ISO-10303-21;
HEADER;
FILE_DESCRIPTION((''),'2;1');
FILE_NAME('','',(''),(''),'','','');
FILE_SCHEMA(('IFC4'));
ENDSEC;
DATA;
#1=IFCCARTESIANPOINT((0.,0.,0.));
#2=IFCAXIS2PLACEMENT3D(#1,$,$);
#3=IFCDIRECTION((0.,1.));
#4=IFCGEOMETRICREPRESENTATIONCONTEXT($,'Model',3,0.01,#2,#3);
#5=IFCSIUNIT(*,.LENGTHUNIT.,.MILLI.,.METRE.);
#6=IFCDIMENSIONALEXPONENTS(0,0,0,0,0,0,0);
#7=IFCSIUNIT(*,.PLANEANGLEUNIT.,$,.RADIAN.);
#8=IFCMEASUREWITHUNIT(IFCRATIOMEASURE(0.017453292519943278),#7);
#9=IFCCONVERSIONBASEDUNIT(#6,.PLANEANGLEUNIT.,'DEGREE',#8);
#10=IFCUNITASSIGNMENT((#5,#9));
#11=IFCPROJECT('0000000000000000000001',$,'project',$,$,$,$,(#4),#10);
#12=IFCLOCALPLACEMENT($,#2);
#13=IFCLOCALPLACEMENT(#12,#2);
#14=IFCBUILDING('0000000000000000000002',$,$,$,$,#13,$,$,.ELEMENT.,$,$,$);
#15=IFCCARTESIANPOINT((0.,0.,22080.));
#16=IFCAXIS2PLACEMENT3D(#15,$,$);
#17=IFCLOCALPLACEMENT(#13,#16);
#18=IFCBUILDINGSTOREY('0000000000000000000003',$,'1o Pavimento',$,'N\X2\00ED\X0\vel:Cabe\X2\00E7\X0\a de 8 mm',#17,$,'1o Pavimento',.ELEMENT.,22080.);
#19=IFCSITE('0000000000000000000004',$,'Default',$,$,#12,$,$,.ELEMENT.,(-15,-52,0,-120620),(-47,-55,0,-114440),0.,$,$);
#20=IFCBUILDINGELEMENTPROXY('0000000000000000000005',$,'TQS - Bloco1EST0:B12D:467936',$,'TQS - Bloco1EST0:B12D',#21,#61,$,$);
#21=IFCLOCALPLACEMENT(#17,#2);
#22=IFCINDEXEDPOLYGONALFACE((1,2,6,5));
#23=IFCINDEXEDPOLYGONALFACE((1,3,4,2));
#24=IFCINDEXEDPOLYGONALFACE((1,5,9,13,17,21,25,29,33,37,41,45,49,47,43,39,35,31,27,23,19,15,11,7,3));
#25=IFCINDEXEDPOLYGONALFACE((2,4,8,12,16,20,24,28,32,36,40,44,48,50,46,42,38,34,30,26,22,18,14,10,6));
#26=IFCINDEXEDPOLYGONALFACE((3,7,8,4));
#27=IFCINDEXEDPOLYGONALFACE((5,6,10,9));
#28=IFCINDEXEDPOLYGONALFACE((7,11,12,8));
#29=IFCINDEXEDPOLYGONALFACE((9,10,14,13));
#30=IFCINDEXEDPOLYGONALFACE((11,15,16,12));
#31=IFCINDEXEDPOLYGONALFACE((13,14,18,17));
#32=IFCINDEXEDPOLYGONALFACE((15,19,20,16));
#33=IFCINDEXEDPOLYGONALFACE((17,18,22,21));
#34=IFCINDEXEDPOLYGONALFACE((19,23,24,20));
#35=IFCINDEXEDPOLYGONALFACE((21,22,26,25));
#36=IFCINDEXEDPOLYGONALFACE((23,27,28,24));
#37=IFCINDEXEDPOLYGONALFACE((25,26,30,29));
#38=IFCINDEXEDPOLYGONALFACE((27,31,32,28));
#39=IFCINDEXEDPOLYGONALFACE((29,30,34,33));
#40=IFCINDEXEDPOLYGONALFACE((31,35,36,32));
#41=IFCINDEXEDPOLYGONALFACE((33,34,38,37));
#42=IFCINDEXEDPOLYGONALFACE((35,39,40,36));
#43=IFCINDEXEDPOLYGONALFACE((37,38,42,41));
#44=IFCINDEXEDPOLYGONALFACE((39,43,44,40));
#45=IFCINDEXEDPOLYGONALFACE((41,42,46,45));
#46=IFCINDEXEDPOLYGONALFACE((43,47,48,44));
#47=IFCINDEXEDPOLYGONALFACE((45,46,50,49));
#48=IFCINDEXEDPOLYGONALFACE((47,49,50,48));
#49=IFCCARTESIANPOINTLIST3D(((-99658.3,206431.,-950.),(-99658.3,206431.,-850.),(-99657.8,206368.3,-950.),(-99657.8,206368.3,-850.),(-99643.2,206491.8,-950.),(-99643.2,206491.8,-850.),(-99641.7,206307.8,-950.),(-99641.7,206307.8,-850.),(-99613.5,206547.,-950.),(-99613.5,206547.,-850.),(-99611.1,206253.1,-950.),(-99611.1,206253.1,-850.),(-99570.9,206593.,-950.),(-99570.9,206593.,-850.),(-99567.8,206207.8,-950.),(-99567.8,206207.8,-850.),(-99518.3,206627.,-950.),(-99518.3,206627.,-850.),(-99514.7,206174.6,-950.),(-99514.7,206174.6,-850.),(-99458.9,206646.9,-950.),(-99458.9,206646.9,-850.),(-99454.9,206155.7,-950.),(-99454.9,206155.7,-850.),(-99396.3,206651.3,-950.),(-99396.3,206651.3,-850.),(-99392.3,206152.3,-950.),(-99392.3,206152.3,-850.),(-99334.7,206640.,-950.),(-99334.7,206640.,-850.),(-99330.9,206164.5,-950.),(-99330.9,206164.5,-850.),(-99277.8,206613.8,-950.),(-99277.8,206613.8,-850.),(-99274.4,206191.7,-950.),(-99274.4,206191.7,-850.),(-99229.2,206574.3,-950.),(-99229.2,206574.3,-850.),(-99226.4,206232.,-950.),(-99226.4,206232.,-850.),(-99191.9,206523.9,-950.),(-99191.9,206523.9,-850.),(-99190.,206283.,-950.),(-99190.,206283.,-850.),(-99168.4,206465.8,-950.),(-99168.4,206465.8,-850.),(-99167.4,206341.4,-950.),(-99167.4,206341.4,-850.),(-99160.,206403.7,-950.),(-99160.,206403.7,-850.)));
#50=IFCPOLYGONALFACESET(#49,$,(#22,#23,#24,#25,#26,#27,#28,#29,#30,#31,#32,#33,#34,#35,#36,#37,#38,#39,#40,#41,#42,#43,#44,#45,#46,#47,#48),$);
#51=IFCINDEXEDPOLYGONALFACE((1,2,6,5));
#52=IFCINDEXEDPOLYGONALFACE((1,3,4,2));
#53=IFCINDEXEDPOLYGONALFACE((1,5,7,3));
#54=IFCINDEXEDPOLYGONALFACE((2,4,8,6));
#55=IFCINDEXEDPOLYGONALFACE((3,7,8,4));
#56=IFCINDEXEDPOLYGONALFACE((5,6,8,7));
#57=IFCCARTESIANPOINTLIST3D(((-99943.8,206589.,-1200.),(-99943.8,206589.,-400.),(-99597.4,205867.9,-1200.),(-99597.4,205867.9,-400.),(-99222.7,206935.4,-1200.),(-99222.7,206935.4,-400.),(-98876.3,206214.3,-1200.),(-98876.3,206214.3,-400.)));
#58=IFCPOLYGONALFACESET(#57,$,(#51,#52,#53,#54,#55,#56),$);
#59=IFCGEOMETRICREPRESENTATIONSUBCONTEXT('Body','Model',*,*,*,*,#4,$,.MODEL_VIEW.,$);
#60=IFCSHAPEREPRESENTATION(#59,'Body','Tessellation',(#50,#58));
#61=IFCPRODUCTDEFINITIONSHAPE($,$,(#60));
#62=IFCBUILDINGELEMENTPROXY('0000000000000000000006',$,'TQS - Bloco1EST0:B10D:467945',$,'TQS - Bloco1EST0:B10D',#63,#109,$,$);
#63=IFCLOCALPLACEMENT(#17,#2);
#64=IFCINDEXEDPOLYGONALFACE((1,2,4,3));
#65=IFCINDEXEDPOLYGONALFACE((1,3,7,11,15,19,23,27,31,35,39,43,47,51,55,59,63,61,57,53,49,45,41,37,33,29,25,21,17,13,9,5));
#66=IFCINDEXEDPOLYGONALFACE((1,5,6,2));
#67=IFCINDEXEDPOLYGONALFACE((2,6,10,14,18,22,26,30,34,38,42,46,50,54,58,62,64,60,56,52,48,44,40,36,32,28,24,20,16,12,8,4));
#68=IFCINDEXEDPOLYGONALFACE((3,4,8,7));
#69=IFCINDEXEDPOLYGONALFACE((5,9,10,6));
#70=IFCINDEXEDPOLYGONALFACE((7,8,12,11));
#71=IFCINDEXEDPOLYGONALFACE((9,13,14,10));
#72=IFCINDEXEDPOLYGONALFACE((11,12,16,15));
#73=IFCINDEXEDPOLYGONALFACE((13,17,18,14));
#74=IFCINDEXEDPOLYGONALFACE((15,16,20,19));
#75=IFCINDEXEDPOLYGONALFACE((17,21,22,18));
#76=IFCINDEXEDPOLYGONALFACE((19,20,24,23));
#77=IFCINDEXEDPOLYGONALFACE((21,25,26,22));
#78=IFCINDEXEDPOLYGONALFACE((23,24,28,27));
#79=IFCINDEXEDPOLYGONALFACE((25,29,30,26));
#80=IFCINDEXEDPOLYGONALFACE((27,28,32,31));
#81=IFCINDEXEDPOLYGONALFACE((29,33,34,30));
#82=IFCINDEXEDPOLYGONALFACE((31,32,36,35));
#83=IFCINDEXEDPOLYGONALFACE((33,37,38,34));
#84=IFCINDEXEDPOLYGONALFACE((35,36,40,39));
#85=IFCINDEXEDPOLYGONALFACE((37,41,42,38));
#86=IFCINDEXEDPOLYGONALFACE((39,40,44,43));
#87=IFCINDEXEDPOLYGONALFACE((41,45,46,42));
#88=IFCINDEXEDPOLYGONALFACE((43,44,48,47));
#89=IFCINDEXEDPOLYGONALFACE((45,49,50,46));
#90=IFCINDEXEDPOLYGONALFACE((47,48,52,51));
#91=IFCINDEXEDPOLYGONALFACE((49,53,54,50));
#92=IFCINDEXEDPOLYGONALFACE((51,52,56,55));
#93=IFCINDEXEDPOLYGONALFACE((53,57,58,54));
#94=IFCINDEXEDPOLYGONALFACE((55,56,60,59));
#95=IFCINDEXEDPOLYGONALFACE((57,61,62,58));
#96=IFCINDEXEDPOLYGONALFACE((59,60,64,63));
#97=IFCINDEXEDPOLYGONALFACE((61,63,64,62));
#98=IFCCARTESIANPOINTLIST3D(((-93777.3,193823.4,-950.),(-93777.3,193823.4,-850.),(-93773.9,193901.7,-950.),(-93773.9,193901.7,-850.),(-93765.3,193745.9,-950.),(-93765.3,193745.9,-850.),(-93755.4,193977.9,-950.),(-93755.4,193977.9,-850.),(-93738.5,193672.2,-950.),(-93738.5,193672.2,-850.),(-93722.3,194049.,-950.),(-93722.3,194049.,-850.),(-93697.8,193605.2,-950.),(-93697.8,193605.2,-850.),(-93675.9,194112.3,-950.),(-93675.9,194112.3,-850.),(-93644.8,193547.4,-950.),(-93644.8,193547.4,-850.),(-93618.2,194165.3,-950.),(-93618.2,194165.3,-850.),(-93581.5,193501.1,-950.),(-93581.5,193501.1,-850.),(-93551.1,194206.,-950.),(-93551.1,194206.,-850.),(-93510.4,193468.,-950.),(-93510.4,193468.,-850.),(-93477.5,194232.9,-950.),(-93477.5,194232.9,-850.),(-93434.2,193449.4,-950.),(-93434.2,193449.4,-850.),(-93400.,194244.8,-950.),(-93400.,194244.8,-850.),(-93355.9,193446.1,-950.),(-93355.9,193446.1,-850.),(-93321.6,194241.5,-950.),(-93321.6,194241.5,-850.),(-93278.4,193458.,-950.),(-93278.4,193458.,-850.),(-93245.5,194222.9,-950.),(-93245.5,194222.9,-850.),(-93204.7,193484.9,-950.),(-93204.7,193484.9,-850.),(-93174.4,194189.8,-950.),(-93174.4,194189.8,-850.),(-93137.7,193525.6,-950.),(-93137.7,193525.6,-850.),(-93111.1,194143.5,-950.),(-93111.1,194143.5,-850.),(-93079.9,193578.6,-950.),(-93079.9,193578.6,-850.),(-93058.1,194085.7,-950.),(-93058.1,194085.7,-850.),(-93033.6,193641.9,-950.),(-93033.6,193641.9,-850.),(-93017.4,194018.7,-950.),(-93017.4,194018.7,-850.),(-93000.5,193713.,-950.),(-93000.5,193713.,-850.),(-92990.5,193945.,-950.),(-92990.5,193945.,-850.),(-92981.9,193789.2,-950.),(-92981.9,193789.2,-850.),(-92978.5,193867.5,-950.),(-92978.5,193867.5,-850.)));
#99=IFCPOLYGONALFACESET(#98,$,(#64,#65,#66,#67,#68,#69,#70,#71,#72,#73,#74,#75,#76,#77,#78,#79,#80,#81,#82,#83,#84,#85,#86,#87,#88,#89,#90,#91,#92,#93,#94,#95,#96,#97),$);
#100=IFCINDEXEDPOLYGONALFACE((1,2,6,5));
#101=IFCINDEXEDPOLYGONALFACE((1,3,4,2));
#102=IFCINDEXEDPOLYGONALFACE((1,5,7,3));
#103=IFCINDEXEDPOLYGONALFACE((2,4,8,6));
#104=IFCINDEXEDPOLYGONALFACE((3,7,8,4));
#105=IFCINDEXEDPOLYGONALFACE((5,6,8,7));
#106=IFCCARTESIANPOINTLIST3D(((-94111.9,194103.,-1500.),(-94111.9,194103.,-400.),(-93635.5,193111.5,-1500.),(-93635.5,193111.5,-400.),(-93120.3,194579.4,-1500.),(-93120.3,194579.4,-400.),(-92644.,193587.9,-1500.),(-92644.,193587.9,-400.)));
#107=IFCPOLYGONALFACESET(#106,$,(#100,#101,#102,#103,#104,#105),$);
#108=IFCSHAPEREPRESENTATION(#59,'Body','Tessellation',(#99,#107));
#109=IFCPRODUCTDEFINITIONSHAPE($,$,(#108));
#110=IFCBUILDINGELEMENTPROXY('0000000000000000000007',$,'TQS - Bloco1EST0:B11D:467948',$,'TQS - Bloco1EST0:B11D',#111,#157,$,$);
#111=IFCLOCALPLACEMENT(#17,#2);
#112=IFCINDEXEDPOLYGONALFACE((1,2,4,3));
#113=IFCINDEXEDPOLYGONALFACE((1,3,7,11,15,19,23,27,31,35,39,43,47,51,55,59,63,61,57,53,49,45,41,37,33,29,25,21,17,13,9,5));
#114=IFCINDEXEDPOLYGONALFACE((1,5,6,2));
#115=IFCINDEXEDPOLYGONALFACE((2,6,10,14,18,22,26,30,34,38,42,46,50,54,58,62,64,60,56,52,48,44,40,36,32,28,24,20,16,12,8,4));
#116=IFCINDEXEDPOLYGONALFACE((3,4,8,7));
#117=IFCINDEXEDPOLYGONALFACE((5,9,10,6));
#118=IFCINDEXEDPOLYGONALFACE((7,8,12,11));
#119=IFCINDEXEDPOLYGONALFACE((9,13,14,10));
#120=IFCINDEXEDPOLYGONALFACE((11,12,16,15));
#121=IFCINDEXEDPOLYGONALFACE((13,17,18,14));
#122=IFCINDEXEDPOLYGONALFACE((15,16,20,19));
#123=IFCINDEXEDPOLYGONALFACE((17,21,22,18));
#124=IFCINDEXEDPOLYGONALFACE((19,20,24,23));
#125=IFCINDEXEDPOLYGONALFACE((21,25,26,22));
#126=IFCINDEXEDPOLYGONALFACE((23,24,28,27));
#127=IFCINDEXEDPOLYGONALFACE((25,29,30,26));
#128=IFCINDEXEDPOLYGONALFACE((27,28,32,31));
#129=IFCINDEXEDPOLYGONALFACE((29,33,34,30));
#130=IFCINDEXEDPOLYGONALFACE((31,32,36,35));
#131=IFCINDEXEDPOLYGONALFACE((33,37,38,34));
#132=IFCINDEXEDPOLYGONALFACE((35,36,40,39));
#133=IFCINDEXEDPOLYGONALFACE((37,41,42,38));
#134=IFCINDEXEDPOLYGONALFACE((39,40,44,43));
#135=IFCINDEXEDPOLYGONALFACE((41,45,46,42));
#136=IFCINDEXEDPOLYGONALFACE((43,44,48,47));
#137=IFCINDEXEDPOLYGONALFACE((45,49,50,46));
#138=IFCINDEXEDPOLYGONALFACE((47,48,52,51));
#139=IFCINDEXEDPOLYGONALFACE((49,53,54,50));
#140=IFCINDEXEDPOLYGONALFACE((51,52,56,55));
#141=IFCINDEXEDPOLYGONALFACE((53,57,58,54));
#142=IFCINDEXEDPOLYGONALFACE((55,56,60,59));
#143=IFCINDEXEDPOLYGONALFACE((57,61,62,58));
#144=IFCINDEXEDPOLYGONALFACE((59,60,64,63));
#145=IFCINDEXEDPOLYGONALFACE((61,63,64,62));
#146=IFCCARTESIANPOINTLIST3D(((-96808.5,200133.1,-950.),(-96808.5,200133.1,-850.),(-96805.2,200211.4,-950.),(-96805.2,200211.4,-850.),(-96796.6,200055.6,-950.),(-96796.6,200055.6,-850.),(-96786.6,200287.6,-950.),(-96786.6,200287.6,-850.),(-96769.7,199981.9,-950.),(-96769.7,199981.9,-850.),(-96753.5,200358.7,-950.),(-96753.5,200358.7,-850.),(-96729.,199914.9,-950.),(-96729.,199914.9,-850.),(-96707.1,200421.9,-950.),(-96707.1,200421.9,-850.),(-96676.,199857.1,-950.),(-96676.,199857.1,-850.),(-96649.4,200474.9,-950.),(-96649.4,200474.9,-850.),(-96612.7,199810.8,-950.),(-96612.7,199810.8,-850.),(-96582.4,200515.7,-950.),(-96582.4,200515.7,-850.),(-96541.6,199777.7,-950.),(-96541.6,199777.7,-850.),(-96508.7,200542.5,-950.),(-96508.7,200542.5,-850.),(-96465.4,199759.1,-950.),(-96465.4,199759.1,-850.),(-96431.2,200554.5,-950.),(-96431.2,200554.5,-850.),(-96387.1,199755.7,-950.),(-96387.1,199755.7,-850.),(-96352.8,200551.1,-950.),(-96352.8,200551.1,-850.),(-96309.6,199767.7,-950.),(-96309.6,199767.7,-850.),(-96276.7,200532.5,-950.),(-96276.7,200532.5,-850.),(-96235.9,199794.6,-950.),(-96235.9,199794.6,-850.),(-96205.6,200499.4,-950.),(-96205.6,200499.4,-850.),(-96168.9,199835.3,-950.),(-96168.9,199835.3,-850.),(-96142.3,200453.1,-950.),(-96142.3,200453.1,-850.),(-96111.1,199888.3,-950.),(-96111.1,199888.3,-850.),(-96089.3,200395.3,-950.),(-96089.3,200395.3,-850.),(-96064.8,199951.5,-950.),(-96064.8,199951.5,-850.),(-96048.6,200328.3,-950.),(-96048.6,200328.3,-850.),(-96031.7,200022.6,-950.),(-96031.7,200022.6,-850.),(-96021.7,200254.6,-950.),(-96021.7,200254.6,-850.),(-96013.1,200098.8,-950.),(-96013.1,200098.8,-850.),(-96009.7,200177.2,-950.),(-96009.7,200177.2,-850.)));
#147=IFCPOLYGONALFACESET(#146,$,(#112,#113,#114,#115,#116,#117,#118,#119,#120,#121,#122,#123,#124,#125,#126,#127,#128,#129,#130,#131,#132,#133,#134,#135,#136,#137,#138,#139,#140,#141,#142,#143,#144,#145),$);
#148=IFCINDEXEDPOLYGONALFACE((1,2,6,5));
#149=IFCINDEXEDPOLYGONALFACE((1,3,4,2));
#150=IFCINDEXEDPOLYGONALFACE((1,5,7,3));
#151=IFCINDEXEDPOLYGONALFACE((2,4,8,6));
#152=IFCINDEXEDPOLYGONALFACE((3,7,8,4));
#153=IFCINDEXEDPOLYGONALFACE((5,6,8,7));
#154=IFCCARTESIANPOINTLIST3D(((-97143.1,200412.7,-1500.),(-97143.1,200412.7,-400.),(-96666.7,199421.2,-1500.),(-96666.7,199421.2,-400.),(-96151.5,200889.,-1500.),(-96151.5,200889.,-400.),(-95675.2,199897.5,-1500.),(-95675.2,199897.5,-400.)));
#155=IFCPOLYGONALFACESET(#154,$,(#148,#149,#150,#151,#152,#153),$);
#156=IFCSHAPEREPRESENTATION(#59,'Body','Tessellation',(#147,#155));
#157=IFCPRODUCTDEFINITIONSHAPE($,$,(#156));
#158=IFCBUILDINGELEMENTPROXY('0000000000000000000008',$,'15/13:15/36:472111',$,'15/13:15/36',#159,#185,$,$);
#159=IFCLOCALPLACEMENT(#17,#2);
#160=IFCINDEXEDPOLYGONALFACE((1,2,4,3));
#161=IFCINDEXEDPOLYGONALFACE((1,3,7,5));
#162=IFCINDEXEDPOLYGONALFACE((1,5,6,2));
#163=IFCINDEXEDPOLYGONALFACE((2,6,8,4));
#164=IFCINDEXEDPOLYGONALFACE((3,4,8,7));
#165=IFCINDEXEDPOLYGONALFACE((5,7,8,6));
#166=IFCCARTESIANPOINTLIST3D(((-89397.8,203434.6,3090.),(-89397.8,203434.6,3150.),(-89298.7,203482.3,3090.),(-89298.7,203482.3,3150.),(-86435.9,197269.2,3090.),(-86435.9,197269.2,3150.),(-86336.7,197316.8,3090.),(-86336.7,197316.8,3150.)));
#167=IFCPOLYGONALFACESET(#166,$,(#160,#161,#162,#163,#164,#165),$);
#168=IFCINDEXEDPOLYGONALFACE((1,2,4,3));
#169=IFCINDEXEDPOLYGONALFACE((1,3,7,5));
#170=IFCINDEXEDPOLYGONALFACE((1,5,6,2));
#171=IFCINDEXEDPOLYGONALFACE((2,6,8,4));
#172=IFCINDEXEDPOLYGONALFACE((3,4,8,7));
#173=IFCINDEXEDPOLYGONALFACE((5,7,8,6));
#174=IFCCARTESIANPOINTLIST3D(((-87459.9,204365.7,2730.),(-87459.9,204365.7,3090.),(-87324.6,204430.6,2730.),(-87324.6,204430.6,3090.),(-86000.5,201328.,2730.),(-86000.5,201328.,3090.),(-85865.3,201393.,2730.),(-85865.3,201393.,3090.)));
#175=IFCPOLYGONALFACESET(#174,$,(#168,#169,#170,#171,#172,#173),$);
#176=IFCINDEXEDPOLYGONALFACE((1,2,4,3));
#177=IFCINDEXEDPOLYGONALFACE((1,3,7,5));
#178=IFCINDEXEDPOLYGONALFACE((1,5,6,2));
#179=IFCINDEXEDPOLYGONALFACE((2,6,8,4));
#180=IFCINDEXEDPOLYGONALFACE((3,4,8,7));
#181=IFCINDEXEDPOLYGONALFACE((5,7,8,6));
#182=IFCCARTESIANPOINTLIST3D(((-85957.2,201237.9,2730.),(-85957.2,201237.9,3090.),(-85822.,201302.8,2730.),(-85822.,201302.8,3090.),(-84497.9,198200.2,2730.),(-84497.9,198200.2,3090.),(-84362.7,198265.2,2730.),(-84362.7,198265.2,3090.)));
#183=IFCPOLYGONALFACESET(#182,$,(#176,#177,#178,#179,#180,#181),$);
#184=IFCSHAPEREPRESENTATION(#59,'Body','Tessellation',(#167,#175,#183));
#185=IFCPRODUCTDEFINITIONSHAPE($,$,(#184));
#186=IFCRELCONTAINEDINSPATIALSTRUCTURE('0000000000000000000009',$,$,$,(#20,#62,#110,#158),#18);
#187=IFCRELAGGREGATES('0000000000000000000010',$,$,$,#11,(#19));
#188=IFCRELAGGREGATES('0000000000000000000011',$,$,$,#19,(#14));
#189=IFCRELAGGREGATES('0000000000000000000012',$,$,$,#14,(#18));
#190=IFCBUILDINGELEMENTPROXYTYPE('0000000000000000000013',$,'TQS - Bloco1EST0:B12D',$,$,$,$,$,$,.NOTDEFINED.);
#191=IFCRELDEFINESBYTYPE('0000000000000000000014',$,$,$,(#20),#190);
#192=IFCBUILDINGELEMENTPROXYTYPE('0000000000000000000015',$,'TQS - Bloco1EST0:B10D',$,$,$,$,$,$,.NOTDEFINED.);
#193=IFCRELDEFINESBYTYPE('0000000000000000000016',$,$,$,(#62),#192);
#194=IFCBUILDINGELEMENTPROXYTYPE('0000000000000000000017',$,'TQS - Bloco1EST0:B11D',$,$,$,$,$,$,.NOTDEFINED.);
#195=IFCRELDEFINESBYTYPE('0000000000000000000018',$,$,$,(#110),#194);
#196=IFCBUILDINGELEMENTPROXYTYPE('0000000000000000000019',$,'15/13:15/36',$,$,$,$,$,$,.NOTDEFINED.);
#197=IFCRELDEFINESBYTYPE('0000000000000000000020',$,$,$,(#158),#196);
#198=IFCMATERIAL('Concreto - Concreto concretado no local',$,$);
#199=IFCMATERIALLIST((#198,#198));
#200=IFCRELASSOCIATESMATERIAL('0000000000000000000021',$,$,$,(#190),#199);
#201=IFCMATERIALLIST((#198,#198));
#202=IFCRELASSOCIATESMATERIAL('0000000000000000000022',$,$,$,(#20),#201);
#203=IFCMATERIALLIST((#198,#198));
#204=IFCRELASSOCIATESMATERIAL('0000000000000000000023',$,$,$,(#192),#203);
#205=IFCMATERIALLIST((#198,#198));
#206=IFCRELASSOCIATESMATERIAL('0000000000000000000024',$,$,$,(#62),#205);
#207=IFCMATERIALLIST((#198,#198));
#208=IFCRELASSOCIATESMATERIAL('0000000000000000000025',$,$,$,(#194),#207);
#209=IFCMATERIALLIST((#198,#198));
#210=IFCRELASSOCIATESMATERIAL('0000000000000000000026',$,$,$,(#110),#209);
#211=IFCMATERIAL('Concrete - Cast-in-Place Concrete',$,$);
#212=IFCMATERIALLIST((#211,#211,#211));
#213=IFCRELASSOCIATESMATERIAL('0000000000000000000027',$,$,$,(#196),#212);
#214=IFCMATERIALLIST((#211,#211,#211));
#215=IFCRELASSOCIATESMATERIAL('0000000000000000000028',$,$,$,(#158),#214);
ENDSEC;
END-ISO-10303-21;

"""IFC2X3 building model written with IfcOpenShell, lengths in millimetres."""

from ifc_helpers import new_model, entity, si_unit, converted_unit, direction, frame, frame_2d, origin, origin_2d_with_axis, place, context, subcontext, project, spatial, rectangle, circle, extrude, source, transform, mapped, material, material_list, type_object, type_shapes, element, save


model = new_model("IFC2X3")

# Units and contexts
model_context = context("Model", 3, precision=0.01, world=origin(), true_north=direction((0.0, 1.0)))
body_context = subcontext(model_context, "Body", "Model", "MODEL_VIEW")
ifc_project = project(units=[si_unit("LENGTHUNIT", "METRE", prefix="MILLI"), converted_unit("PLANEANGLEUNIT", "DEGREE", entity("IfcRatioMeasure", 0.017453292519943278), si_unit("PLANEANGLEUNIT", "RADIAN"), dimensions=[0, 0, 0, 0, 0, 0, 0])], contexts=[model_context])

# Site, building, storey
site_placement = place(None, origin())
site = spatial("IfcSite", under=ifc_project, at=site_placement, Name="Default", CompositionType="ELEMENT", RefLatitude=(-15, -52, 0, -120620), RefLongitude=(-47, -55, 0, -114440), RefElevation=0.0)
building_placement = place(site_placement, origin())
building = spatial("IfcBuilding", under=site, at=building_placement, CompositionType="ELEMENT")
storey_placement = place(building_placement, frame((0.0, 0.0, 22080.0)))
storey = spatial("IfcBuildingStorey", under=building, at=storey_placement, Name="1o Pavimento", ObjectType="Nível:Cabeça de 8 mm", LongName="1o Pavimento", CompositionType="ELEMENT", Elevation=22080.0)

# Building element proxies
ifc_material_1 = material(Name="Concreto - Concreto concretado no local")
ifc_material_list_1 = material_list([ifc_material_1, ifc_material_1])
ifc_material_list_2 = material_list([ifc_material_1, ifc_material_1])
building_element_proxy_type_1 = type_object("IfcBuildingElementProxyType", Name="TQS - Bloco1EST0:B12D", PredefinedType="NOTDEFINED", material=ifc_material_list_2)
shared_shape_1 = source(origin(), body_context, "Body", "SweptSolid", [
    extrude(circle(Radius=250.0, at=frame_2d((0.0, 0.0), x_axis=(1.0, 0.0))), frame((0.0, 0.0, -550.0)), (0.0, 0.0, 1.0), 100.0),
    extrude(rectangle(XDim=800.0, YDim=800.0, at=origin_2d_with_axis()), frame((0.0, 0.0, -800.0), z_axis=(0.0, 0.0, 1.0), x_axis=(-1.0, 0.0, 0.0)), (0.0, 0.0, 1.0), 800.0),
])
type_shapes(building_element_proxy_type_1, [shared_shape_1])
proxy_1_placement = place(storey_placement, frame((-99410.0, 206401.7, -400.0), z_axis=(0.0, 0.0, 1.0), x_axis=(-0.43303, 0.90138, 0.0)))
element("IfcBuildingElementProxy", 1, at=proxy_1_placement, inside=storey, type_object=building_element_proxy_type_1, material=ifc_material_list_1, Name="TQS - Bloco1EST0:B12D:467936", ObjectType="TQS - Bloco1EST0:B12D", context=body_context, shape_type="MappedRepresentation", body=[
    mapped(shared_shape_1, transform((0.0, 0.0, 0.0), scale=1.0)),
])
ifc_material_list_3 = material_list([ifc_material_1, ifc_material_1])
ifc_material_list_4 = material_list([ifc_material_1, ifc_material_1])
building_element_proxy_type_2 = type_object("IfcBuildingElementProxyType", Name="TQS - Bloco1EST0:B10D", PredefinedType="NOTDEFINED", material=ifc_material_list_4)
shared_shape_2 = source(origin(), body_context, "Body", "SweptSolid", [
    extrude(circle(Radius=400.0, at=frame_2d((0.0, 0.0), x_axis=(1.0, 0.0))), frame((0.0, 0.0, -550.0)), (0.0, 0.0, 1.0), 100.0),
    extrude(rectangle(XDim=1100.0, YDim=1100.0, at=origin_2d_with_axis()), frame((0.0, 0.0, -1100.0), z_axis=(0.0, 0.0, 1.0), x_axis=(-1.0, 0.0, 0.0)), (0.0, 0.0, 1.0), 1100.0),
])
type_shapes(building_element_proxy_type_2, [shared_shape_2])
proxy_2_placement = place(storey_placement, frame((-93377.9, 193845.4, -400.0), z_axis=(0.0, 0.0, 1.0), x_axis=(-0.43303, 0.90138, 0.0)))
element("IfcBuildingElementProxy", 2, at=proxy_2_placement, inside=storey, type_object=building_element_proxy_type_2, material=ifc_material_list_3, Name="TQS - Bloco1EST0:B10D:467945", ObjectType="TQS - Bloco1EST0:B10D", context=body_context, shape_type="MappedRepresentation", body=[
    mapped(shared_shape_2, transform((0.0, 0.0, 0.0), scale=1.0)),
])
ifc_material_list_5 = material_list([ifc_material_1, ifc_material_1])
ifc_material_list_6 = material_list([ifc_material_1, ifc_material_1])
building_element_proxy_type_3 = type_object("IfcBuildingElementProxyType", Name="TQS - Bloco1EST0:B11D", PredefinedType="NOTDEFINED", material=ifc_material_list_6)
shared_shape_3 = source(origin(), body_context, "Body", "SweptSolid", [
    extrude(circle(Radius=400.0, at=frame_2d((0.0, 0.0), x_axis=(1.0, 0.0))), frame((0.0, 0.0, -550.0)), (0.0, 0.0, 1.0), 100.0),
    extrude(rectangle(XDim=1100.0, YDim=1100.0, at=origin_2d_with_axis()), frame((0.0, 0.0, -1100.0), z_axis=(0.0, 0.0, 1.0), x_axis=(-1.0, 0.0, 0.0)), (0.0, 0.0, 1.0), 1100.0),
])
type_shapes(building_element_proxy_type_3, [shared_shape_3])
proxy_3_placement = place(storey_placement, frame((-96409.1, 200155.1, -400.0), z_axis=(0.0, 0.0, 1.0), x_axis=(-0.43303, 0.90138, 0.0)))
element("IfcBuildingElementProxy", 3, at=proxy_3_placement, inside=storey, type_object=building_element_proxy_type_3, material=ifc_material_list_5, Name="TQS - Bloco1EST0:B11D:467948", ObjectType="TQS - Bloco1EST0:B11D", context=body_context, shape_type="MappedRepresentation", body=[
    mapped(shared_shape_3, transform((0.0, 0.0, 0.0), scale=1.0)),
])
ifc_material_2 = material(Name="Concrete - Cast-in-Place Concrete")
ifc_material_list_7 = material_list([ifc_material_2, ifc_material_2, ifc_material_2])
ifc_material_list_8 = material_list([ifc_material_2, ifc_material_2, ifc_material_2])
building_element_proxy_type_4 = type_object("IfcBuildingElementProxyType", Name="15/13:15/36", PredefinedType="NOTDEFINED", material=ifc_material_list_8)
shared_shape_4 = source(origin(), body_context, "Body", "SweptSolid", [
    extrude(rectangle(XDim=110.0, YDim=6840.0, at=frame_2d((0.0, 0.0), x_axis=(1.0, 0.0))), frame((1530.5, 3106.5, 360.0), z_axis=(0.0, 0.0, 1.0), x_axis=(0.90138, 0.43303, 0.0)), (0.0, 0.0, 1.0), 60.0),
    extrude(rectangle(XDim=3370.0, YDim=150.0, at=frame_2d((0.0, 0.0), x_axis=(1.0, 0.0))), frame((2735.2, 5610.1, 0.0), z_axis=(0.0, 0.0, 1.0), x_axis=(0.43303, -0.90138, 0.0)), (0.0, 0.0, 1.0), 360.0),
    extrude(rectangle(XDim=3370.0, YDim=150.0, at=frame_2d((0.0, 0.0), x_axis=(1.0, 0.0))), frame((4237.8, 2482.3, 0.0), z_axis=(0.0, 0.0, 1.0), x_axis=(0.43303, -0.90138, 0.0)), (0.0, 0.0, 1.0), 360.0),
])
type_shapes(building_element_proxy_type_4, [shared_shape_4])
proxy_4_placement = place(storey_placement, frame((-89397.8, 197269.2, 2730.0)))
element("IfcBuildingElementProxy", 4, at=proxy_4_placement, inside=storey, type_object=building_element_proxy_type_4, material=ifc_material_list_7, Name="15/13:15/36:472111", ObjectType="15/13:15/36", context=body_context, shape_type="MappedRepresentation", body=[
    mapped(shared_shape_4, transform((0.0, 0.0, 0.0), scale=1.0)),
])

save(model, "model.ifc")
